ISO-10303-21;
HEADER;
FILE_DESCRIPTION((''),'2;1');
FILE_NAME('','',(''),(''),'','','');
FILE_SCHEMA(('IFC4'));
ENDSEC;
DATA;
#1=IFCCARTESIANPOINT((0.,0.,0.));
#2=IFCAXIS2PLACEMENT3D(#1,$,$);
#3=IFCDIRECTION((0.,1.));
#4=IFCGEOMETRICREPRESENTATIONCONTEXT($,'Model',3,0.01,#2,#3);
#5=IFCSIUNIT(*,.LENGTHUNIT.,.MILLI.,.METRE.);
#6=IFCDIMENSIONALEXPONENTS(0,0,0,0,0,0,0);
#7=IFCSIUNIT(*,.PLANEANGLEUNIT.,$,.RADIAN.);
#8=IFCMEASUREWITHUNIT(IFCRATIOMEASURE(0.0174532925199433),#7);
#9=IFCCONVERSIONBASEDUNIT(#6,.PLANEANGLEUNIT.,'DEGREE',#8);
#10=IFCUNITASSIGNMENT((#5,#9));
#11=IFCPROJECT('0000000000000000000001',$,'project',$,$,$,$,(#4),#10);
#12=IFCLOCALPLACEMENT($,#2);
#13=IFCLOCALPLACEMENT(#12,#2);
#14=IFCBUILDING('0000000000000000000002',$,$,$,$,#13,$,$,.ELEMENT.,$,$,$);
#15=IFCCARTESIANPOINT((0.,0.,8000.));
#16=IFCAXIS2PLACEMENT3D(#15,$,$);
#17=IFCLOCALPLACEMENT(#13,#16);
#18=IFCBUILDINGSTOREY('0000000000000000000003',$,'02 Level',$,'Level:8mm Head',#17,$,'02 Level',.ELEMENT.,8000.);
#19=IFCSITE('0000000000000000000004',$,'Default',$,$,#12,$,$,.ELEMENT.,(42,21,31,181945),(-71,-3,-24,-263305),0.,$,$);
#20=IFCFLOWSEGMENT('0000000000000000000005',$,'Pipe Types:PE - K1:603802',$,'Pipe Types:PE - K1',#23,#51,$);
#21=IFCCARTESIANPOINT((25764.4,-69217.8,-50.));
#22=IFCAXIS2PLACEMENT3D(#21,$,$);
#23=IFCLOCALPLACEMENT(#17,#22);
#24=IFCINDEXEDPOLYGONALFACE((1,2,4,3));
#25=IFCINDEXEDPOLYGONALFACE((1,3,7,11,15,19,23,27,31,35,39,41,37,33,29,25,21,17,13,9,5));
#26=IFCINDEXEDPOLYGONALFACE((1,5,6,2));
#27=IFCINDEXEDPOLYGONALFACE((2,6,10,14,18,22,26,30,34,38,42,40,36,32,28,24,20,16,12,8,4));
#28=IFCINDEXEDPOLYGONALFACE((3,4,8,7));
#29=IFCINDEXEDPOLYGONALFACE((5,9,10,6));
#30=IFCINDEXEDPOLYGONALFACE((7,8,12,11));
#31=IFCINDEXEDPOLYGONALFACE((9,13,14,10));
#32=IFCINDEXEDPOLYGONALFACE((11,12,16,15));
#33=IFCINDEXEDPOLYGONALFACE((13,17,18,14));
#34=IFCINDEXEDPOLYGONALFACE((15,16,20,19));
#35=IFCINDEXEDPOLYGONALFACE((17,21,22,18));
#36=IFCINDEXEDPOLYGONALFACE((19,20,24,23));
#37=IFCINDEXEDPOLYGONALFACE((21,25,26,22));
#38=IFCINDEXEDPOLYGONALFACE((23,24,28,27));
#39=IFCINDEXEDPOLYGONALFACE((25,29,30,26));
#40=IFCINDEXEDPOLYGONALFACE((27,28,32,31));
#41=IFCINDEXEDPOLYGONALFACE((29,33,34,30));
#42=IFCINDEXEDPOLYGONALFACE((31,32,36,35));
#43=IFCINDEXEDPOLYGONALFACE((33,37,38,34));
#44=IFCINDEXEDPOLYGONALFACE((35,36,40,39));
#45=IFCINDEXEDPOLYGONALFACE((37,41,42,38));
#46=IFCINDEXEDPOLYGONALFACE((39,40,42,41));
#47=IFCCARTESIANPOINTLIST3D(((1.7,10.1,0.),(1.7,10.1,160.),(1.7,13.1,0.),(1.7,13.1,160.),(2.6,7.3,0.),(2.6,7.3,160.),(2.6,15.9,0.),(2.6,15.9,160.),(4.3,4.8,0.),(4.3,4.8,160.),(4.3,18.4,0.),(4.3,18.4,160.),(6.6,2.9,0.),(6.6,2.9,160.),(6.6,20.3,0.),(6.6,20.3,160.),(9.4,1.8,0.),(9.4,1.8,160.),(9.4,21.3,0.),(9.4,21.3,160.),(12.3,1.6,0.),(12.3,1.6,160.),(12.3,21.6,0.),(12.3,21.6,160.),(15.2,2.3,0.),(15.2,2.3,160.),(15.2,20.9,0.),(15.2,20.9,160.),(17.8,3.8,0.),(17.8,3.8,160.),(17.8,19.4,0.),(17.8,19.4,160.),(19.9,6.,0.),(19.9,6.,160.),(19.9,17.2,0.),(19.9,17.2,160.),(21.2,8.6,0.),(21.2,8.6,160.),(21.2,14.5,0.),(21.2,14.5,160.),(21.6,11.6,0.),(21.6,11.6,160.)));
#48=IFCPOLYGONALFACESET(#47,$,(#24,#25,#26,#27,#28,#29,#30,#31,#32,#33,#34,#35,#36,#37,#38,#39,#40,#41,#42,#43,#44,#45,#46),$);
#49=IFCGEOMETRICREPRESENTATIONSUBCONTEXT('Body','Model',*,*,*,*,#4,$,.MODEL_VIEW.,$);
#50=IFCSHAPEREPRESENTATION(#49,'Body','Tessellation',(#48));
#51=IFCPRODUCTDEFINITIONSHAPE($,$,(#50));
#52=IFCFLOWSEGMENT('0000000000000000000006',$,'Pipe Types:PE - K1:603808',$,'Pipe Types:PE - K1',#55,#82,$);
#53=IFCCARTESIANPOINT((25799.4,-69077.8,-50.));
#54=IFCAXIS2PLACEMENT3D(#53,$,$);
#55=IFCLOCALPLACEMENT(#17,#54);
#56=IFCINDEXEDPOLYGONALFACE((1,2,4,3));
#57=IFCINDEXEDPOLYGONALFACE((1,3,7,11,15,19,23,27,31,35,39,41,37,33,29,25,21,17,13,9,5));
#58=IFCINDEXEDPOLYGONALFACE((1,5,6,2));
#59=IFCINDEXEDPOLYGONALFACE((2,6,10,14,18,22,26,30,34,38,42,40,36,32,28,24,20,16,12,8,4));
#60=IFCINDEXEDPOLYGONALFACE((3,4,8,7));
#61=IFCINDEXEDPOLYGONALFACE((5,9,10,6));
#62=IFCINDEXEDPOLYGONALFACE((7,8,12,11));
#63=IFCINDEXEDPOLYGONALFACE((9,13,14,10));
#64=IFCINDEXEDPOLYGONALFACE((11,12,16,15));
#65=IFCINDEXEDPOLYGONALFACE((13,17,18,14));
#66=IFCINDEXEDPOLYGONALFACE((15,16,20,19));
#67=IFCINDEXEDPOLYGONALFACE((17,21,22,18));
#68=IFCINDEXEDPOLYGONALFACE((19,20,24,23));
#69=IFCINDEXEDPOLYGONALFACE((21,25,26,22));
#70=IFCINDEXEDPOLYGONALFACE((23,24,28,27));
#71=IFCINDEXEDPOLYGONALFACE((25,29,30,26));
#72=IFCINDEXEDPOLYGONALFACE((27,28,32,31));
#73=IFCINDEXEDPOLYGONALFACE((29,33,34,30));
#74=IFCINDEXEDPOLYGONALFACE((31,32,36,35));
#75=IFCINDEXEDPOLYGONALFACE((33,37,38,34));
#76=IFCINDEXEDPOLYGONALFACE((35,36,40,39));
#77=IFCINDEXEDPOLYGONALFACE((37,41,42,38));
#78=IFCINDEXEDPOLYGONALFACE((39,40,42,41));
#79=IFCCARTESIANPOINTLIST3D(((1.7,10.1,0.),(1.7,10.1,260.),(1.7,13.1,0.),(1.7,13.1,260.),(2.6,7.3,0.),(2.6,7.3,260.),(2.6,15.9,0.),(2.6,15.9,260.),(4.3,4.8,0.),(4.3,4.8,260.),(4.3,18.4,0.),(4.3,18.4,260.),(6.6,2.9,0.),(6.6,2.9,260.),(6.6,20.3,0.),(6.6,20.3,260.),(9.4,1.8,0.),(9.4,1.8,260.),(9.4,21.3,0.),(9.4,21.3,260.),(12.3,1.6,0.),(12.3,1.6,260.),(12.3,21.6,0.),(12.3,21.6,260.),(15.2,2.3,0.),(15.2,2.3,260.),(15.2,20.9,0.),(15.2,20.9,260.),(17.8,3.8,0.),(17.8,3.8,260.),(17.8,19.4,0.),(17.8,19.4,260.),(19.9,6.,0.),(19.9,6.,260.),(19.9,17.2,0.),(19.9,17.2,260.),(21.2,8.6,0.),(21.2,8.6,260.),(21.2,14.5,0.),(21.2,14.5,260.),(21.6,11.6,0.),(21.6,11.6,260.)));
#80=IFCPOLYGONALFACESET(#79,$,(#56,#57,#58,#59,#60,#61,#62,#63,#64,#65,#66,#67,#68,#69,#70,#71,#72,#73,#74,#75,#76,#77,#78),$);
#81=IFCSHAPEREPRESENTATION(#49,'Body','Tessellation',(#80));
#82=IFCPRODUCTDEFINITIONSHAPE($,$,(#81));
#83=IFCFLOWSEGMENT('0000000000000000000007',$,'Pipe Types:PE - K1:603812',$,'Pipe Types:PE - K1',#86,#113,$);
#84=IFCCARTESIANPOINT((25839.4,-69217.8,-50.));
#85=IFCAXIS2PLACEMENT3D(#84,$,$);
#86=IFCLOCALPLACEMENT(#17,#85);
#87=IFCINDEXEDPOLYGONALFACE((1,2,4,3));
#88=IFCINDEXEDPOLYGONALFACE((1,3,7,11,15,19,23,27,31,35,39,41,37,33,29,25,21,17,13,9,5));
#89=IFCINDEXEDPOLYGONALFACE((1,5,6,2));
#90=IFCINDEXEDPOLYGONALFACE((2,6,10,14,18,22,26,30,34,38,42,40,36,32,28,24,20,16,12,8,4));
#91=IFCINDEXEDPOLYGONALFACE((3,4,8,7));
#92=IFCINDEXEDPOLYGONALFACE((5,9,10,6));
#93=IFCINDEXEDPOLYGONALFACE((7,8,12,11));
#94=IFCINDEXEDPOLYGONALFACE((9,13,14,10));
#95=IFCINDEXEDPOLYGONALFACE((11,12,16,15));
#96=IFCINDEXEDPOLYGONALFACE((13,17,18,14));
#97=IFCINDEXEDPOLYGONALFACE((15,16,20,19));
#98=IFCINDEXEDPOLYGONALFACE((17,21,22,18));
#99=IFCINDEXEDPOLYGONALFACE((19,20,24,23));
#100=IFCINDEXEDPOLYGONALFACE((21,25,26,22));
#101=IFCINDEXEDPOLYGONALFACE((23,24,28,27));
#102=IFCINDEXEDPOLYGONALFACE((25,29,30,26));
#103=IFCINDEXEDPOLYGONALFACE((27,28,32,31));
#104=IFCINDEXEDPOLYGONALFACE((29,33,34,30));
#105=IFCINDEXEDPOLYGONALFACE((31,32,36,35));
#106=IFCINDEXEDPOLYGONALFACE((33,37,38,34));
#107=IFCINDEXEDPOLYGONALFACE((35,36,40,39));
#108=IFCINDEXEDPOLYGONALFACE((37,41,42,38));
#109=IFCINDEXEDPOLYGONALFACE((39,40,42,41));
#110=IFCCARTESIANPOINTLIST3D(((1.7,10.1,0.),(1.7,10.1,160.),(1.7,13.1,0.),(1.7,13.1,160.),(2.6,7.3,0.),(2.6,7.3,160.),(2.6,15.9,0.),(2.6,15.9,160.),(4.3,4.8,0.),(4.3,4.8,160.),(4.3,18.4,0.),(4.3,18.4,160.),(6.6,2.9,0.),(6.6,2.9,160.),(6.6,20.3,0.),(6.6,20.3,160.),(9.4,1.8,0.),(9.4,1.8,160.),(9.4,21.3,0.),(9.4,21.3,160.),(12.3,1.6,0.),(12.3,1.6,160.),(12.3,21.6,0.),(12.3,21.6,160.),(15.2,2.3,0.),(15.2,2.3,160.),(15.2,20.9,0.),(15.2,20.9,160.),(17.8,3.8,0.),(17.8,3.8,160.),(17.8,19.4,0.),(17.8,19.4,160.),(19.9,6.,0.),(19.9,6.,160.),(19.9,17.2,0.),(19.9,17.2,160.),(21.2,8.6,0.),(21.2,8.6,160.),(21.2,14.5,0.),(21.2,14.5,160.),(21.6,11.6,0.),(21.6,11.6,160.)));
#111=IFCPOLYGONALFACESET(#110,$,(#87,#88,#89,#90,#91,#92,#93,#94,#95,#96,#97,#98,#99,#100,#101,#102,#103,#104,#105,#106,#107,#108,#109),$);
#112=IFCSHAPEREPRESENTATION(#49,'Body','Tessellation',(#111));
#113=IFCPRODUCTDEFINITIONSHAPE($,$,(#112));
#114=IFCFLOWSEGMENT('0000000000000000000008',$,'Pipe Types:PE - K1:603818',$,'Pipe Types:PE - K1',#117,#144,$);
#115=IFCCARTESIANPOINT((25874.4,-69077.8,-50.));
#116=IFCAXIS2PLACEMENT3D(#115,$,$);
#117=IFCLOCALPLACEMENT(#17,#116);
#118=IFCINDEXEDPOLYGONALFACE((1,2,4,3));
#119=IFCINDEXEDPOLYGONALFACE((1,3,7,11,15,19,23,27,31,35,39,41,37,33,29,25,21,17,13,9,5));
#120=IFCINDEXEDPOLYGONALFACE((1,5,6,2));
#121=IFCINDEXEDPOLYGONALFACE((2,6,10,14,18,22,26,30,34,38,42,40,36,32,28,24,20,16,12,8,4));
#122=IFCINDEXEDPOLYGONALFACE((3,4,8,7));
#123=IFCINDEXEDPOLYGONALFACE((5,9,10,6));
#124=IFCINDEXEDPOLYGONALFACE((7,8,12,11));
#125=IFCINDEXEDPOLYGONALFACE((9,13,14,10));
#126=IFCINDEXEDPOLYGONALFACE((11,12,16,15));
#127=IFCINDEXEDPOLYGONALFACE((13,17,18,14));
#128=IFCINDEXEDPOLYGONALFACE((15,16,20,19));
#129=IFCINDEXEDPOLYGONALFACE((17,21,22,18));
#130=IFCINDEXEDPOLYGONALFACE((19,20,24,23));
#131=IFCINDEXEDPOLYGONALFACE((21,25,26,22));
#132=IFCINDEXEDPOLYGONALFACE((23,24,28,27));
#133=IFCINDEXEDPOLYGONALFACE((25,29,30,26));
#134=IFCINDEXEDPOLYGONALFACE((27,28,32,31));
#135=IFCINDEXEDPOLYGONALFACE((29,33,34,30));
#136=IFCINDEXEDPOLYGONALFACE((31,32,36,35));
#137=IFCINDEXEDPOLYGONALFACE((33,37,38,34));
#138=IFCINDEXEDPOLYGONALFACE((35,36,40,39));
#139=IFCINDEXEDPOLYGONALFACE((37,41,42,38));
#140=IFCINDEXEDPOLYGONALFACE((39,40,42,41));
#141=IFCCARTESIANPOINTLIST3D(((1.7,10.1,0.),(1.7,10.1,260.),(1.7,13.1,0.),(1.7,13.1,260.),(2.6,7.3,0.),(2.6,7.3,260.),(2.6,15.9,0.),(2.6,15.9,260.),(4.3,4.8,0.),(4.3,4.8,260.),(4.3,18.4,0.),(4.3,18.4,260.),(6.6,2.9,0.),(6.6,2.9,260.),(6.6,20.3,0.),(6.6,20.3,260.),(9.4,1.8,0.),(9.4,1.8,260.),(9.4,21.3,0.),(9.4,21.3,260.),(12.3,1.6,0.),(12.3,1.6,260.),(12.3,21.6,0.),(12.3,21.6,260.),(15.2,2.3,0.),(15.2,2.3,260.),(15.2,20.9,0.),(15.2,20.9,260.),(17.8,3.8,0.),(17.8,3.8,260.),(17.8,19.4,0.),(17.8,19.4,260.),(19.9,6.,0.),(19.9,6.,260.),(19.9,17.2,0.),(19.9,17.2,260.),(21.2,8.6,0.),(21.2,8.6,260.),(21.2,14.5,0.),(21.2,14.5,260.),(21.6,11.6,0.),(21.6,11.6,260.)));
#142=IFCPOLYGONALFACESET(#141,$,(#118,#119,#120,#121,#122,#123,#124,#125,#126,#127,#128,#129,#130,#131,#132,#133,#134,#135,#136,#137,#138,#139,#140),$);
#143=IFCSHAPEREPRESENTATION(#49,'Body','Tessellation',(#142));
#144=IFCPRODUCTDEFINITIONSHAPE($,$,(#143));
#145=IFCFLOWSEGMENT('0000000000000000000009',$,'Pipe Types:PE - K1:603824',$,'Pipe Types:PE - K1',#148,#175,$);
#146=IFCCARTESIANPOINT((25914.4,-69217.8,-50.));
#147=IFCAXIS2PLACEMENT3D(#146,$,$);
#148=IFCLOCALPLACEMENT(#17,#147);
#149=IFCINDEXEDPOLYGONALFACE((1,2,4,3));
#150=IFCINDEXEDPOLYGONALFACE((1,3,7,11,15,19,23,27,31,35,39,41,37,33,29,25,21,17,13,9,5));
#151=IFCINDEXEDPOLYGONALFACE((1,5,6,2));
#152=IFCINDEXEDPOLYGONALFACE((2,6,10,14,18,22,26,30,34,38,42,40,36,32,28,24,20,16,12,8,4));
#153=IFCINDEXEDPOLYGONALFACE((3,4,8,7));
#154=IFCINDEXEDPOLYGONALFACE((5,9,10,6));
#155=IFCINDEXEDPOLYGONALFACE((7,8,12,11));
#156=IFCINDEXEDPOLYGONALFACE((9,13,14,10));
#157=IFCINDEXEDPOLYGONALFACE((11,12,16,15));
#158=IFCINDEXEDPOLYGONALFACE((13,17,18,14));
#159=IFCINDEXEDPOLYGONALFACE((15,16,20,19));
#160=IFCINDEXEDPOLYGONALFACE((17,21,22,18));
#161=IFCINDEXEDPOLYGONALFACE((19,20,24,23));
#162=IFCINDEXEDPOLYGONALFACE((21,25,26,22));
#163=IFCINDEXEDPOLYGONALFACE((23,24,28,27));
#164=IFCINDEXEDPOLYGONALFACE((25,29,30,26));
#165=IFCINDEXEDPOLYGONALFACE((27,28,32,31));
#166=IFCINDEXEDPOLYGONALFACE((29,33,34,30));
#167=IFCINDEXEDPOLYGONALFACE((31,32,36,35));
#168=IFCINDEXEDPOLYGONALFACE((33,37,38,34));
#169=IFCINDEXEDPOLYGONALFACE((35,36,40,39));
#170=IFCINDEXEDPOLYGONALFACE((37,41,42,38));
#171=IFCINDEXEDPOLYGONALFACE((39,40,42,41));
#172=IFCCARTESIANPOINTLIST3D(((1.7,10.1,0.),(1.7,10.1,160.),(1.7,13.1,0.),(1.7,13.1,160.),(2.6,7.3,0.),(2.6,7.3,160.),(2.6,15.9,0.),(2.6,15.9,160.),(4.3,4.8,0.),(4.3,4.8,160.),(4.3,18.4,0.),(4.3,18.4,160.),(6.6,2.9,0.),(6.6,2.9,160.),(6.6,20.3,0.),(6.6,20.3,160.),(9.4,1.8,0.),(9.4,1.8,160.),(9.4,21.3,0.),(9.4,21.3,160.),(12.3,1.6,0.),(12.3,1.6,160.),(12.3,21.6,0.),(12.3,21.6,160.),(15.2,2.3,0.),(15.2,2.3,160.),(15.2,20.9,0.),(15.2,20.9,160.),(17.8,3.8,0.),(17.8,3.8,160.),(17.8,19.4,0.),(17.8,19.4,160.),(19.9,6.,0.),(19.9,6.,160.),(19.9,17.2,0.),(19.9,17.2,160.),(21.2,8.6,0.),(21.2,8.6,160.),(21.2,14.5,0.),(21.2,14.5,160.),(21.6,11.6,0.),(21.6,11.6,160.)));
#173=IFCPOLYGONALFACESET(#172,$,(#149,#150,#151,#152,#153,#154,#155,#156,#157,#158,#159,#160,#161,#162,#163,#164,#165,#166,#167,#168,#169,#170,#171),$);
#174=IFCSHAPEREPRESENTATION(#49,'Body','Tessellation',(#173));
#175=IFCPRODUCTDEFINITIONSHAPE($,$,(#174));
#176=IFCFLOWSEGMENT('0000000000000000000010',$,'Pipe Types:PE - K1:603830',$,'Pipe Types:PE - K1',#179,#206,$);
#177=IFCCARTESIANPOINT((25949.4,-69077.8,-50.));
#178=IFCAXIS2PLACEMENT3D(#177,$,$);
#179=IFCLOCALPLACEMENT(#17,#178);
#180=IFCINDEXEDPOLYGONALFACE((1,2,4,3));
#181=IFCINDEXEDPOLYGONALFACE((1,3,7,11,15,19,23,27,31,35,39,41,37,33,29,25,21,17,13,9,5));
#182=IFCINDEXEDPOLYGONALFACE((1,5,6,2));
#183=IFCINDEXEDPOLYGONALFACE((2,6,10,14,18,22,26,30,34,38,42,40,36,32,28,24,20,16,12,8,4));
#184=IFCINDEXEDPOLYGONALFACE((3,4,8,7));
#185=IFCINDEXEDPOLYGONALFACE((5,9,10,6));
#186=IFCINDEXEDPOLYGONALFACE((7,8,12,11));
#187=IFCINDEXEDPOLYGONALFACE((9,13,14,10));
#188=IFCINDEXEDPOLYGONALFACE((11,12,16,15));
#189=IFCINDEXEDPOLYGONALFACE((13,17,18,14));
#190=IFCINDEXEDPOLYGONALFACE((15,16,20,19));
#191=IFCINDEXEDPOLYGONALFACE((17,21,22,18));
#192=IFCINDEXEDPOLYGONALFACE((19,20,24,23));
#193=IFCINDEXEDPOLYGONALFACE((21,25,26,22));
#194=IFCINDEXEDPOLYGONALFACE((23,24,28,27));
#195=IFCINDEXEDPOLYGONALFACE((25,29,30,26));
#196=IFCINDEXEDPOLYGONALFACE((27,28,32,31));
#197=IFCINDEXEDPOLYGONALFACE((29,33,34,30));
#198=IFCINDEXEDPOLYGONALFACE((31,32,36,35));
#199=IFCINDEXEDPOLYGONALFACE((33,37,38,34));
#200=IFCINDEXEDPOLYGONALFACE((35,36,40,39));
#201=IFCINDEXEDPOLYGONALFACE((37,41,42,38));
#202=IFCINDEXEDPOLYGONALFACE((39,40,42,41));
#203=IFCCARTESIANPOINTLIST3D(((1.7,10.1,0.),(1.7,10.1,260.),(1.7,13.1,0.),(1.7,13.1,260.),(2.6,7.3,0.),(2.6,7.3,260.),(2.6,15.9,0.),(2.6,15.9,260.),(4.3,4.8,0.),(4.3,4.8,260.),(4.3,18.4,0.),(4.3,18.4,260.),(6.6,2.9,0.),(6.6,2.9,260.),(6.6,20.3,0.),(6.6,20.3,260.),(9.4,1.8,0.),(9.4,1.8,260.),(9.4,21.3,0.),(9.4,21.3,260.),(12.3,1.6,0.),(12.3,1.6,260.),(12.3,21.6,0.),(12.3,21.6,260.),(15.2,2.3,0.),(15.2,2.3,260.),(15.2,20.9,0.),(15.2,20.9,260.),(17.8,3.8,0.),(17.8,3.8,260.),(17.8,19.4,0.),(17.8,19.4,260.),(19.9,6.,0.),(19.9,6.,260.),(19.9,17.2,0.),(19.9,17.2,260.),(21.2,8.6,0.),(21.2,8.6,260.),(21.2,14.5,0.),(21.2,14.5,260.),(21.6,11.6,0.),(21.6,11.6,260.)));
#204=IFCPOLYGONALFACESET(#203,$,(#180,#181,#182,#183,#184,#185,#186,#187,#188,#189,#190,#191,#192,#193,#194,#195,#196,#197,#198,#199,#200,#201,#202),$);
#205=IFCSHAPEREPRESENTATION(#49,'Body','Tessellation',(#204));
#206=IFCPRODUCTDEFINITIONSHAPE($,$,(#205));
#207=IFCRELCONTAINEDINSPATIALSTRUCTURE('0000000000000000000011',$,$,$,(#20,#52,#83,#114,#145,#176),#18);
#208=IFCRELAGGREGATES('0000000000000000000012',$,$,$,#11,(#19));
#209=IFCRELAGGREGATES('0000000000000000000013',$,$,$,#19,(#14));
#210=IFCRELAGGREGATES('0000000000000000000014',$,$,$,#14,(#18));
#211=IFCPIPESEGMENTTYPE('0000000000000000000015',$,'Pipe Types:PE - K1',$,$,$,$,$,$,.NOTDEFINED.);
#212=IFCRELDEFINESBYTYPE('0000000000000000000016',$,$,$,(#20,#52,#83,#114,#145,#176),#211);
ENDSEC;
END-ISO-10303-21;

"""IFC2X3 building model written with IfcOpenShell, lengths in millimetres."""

from ifc_helpers import new_model, entity, si_unit, converted_unit, direction, frame, origin, origin_2d_with_axis, place, context, subcontext, project, spatial, circle, extrude, type_object, element, save


model = new_model("IFC2X3")

# Units and contexts
model_context = context("Model", 3, precision=0.01, world=origin(), true_north=direction((0.0, 1.0)))
body_context = subcontext(model_context, "Body", "Model", "MODEL_VIEW")
ifc_project = project(units=[si_unit("LENGTHUNIT", "METRE", prefix="MILLI"), converted_unit("PLANEANGLEUNIT", "DEGREE", entity("IfcRatioMeasure", 0.0174532925199433), si_unit("PLANEANGLEUNIT", "RADIAN"), dimensions=[0, 0, 0, 0, 0, 0, 0])], contexts=[model_context])

# Site, building, storey
site_placement = place(None, origin())
site = spatial("IfcSite", under=ifc_project, at=site_placement, Name="Default", CompositionType="ELEMENT", RefLatitude=(42, 21, 31, 181945), RefLongitude=(-71, -3, -24, -263305), RefElevation=0.0)
building_placement = place(site_placement, origin())
building = spatial("IfcBuilding", under=site, at=building_placement, CompositionType="ELEMENT")
storey_placement = place(building_placement, frame((0.0, 0.0, 8000.0)))
storey = spatial("IfcBuildingStorey", under=building, at=storey_placement, Name="02 Level", ObjectType="Level:8mm Head", LongName="02 Level", CompositionType="ELEMENT", Elevation=8000.0)

# Flow segments
pipe_segment_type = type_object("IfcPipeSegmentType", Name="Pipe Types:PE - K1", PredefinedType="NOTDEFINED")
flow_segment_1_placement = place(storey_placement, frame((25764.4, -69217.8, -50.0)))
element("IfcFlowSegment", 1, at=flow_segment_1_placement, inside=storey, type_object=pipe_segment_type, Name="Pipe Types:PE - K1:603802", ObjectType="Pipe Types:PE - K1", context=body_context, shape_type="SweptSolid", body=[
    extrude(circle(Radius=10.0, at=origin_2d_with_axis()), frame((11.6, 11.6, 0.0)), (0.0, 0.0, 1.0), 160.0),
])
flow_segment_2_placement = place(storey_placement, frame((25799.4, -69077.8, -50.0)))
element("IfcFlowSegment", 2, at=flow_segment_2_placement, inside=storey, type_object=pipe_segment_type, Name="Pipe Types:PE - K1:603808", ObjectType="Pipe Types:PE - K1", context=body_context, shape_type="SweptSolid", body=[
    extrude(circle(Radius=10.0, at=origin_2d_with_axis()), frame((11.6, 11.6, 0.0)), (0.0, 0.0, 1.0), 260.0),
])
flow_segment_3_placement = place(storey_placement, frame((25839.4, -69217.8, -50.0)))
element("IfcFlowSegment", 3, at=flow_segment_3_placement, inside=storey, type_object=pipe_segment_type, Name="Pipe Types:PE - K1:603812", ObjectType="Pipe Types:PE - K1", context=body_context, shape_type="SweptSolid", body=[
    extrude(circle(Radius=10.0, at=origin_2d_with_axis()), frame((11.6, 11.6, 0.0)), (0.0, 0.0, 1.0), 160.0),
])
flow_segment_4_placement = place(storey_placement, frame((25874.4, -69077.8, -50.0)))
element("IfcFlowSegment", 4, at=flow_segment_4_placement, inside=storey, type_object=pipe_segment_type, Name="Pipe Types:PE - K1:603818", ObjectType="Pipe Types:PE - K1", context=body_context, shape_type="SweptSolid", body=[
    extrude(circle(Radius=10.0, at=origin_2d_with_axis()), frame((11.6, 11.6, 0.0)), (0.0, 0.0, 1.0), 260.0),
])
flow_segment_5_placement = place(storey_placement, frame((25914.4, -69217.8, -50.0)))
element("IfcFlowSegment", 5, at=flow_segment_5_placement, inside=storey, type_object=pipe_segment_type, Name="Pipe Types:PE - K1:603824", ObjectType="Pipe Types:PE - K1", context=body_context, shape_type="SweptSolid", body=[
    extrude(circle(Radius=10.0, at=origin_2d_with_axis()), frame((11.6, 11.6, 0.0)), (0.0, 0.0, 1.0), 160.0),
])
flow_segment_6_placement = place(storey_placement, frame((25949.4, -69077.8, -50.0)))
element("IfcFlowSegment", 6, at=flow_segment_6_placement, inside=storey, type_object=pipe_segment_type, Name="Pipe Types:PE - K1:603830", ObjectType="Pipe Types:PE - K1", context=body_context, shape_type="SweptSolid", body=[
    extrude(circle(Radius=10.0, at=origin_2d_with_axis()), frame((11.6, 11.6, 0.0)), (0.0, 0.0, 1.0), 260.0),
])

save(model, "model.ifc")
